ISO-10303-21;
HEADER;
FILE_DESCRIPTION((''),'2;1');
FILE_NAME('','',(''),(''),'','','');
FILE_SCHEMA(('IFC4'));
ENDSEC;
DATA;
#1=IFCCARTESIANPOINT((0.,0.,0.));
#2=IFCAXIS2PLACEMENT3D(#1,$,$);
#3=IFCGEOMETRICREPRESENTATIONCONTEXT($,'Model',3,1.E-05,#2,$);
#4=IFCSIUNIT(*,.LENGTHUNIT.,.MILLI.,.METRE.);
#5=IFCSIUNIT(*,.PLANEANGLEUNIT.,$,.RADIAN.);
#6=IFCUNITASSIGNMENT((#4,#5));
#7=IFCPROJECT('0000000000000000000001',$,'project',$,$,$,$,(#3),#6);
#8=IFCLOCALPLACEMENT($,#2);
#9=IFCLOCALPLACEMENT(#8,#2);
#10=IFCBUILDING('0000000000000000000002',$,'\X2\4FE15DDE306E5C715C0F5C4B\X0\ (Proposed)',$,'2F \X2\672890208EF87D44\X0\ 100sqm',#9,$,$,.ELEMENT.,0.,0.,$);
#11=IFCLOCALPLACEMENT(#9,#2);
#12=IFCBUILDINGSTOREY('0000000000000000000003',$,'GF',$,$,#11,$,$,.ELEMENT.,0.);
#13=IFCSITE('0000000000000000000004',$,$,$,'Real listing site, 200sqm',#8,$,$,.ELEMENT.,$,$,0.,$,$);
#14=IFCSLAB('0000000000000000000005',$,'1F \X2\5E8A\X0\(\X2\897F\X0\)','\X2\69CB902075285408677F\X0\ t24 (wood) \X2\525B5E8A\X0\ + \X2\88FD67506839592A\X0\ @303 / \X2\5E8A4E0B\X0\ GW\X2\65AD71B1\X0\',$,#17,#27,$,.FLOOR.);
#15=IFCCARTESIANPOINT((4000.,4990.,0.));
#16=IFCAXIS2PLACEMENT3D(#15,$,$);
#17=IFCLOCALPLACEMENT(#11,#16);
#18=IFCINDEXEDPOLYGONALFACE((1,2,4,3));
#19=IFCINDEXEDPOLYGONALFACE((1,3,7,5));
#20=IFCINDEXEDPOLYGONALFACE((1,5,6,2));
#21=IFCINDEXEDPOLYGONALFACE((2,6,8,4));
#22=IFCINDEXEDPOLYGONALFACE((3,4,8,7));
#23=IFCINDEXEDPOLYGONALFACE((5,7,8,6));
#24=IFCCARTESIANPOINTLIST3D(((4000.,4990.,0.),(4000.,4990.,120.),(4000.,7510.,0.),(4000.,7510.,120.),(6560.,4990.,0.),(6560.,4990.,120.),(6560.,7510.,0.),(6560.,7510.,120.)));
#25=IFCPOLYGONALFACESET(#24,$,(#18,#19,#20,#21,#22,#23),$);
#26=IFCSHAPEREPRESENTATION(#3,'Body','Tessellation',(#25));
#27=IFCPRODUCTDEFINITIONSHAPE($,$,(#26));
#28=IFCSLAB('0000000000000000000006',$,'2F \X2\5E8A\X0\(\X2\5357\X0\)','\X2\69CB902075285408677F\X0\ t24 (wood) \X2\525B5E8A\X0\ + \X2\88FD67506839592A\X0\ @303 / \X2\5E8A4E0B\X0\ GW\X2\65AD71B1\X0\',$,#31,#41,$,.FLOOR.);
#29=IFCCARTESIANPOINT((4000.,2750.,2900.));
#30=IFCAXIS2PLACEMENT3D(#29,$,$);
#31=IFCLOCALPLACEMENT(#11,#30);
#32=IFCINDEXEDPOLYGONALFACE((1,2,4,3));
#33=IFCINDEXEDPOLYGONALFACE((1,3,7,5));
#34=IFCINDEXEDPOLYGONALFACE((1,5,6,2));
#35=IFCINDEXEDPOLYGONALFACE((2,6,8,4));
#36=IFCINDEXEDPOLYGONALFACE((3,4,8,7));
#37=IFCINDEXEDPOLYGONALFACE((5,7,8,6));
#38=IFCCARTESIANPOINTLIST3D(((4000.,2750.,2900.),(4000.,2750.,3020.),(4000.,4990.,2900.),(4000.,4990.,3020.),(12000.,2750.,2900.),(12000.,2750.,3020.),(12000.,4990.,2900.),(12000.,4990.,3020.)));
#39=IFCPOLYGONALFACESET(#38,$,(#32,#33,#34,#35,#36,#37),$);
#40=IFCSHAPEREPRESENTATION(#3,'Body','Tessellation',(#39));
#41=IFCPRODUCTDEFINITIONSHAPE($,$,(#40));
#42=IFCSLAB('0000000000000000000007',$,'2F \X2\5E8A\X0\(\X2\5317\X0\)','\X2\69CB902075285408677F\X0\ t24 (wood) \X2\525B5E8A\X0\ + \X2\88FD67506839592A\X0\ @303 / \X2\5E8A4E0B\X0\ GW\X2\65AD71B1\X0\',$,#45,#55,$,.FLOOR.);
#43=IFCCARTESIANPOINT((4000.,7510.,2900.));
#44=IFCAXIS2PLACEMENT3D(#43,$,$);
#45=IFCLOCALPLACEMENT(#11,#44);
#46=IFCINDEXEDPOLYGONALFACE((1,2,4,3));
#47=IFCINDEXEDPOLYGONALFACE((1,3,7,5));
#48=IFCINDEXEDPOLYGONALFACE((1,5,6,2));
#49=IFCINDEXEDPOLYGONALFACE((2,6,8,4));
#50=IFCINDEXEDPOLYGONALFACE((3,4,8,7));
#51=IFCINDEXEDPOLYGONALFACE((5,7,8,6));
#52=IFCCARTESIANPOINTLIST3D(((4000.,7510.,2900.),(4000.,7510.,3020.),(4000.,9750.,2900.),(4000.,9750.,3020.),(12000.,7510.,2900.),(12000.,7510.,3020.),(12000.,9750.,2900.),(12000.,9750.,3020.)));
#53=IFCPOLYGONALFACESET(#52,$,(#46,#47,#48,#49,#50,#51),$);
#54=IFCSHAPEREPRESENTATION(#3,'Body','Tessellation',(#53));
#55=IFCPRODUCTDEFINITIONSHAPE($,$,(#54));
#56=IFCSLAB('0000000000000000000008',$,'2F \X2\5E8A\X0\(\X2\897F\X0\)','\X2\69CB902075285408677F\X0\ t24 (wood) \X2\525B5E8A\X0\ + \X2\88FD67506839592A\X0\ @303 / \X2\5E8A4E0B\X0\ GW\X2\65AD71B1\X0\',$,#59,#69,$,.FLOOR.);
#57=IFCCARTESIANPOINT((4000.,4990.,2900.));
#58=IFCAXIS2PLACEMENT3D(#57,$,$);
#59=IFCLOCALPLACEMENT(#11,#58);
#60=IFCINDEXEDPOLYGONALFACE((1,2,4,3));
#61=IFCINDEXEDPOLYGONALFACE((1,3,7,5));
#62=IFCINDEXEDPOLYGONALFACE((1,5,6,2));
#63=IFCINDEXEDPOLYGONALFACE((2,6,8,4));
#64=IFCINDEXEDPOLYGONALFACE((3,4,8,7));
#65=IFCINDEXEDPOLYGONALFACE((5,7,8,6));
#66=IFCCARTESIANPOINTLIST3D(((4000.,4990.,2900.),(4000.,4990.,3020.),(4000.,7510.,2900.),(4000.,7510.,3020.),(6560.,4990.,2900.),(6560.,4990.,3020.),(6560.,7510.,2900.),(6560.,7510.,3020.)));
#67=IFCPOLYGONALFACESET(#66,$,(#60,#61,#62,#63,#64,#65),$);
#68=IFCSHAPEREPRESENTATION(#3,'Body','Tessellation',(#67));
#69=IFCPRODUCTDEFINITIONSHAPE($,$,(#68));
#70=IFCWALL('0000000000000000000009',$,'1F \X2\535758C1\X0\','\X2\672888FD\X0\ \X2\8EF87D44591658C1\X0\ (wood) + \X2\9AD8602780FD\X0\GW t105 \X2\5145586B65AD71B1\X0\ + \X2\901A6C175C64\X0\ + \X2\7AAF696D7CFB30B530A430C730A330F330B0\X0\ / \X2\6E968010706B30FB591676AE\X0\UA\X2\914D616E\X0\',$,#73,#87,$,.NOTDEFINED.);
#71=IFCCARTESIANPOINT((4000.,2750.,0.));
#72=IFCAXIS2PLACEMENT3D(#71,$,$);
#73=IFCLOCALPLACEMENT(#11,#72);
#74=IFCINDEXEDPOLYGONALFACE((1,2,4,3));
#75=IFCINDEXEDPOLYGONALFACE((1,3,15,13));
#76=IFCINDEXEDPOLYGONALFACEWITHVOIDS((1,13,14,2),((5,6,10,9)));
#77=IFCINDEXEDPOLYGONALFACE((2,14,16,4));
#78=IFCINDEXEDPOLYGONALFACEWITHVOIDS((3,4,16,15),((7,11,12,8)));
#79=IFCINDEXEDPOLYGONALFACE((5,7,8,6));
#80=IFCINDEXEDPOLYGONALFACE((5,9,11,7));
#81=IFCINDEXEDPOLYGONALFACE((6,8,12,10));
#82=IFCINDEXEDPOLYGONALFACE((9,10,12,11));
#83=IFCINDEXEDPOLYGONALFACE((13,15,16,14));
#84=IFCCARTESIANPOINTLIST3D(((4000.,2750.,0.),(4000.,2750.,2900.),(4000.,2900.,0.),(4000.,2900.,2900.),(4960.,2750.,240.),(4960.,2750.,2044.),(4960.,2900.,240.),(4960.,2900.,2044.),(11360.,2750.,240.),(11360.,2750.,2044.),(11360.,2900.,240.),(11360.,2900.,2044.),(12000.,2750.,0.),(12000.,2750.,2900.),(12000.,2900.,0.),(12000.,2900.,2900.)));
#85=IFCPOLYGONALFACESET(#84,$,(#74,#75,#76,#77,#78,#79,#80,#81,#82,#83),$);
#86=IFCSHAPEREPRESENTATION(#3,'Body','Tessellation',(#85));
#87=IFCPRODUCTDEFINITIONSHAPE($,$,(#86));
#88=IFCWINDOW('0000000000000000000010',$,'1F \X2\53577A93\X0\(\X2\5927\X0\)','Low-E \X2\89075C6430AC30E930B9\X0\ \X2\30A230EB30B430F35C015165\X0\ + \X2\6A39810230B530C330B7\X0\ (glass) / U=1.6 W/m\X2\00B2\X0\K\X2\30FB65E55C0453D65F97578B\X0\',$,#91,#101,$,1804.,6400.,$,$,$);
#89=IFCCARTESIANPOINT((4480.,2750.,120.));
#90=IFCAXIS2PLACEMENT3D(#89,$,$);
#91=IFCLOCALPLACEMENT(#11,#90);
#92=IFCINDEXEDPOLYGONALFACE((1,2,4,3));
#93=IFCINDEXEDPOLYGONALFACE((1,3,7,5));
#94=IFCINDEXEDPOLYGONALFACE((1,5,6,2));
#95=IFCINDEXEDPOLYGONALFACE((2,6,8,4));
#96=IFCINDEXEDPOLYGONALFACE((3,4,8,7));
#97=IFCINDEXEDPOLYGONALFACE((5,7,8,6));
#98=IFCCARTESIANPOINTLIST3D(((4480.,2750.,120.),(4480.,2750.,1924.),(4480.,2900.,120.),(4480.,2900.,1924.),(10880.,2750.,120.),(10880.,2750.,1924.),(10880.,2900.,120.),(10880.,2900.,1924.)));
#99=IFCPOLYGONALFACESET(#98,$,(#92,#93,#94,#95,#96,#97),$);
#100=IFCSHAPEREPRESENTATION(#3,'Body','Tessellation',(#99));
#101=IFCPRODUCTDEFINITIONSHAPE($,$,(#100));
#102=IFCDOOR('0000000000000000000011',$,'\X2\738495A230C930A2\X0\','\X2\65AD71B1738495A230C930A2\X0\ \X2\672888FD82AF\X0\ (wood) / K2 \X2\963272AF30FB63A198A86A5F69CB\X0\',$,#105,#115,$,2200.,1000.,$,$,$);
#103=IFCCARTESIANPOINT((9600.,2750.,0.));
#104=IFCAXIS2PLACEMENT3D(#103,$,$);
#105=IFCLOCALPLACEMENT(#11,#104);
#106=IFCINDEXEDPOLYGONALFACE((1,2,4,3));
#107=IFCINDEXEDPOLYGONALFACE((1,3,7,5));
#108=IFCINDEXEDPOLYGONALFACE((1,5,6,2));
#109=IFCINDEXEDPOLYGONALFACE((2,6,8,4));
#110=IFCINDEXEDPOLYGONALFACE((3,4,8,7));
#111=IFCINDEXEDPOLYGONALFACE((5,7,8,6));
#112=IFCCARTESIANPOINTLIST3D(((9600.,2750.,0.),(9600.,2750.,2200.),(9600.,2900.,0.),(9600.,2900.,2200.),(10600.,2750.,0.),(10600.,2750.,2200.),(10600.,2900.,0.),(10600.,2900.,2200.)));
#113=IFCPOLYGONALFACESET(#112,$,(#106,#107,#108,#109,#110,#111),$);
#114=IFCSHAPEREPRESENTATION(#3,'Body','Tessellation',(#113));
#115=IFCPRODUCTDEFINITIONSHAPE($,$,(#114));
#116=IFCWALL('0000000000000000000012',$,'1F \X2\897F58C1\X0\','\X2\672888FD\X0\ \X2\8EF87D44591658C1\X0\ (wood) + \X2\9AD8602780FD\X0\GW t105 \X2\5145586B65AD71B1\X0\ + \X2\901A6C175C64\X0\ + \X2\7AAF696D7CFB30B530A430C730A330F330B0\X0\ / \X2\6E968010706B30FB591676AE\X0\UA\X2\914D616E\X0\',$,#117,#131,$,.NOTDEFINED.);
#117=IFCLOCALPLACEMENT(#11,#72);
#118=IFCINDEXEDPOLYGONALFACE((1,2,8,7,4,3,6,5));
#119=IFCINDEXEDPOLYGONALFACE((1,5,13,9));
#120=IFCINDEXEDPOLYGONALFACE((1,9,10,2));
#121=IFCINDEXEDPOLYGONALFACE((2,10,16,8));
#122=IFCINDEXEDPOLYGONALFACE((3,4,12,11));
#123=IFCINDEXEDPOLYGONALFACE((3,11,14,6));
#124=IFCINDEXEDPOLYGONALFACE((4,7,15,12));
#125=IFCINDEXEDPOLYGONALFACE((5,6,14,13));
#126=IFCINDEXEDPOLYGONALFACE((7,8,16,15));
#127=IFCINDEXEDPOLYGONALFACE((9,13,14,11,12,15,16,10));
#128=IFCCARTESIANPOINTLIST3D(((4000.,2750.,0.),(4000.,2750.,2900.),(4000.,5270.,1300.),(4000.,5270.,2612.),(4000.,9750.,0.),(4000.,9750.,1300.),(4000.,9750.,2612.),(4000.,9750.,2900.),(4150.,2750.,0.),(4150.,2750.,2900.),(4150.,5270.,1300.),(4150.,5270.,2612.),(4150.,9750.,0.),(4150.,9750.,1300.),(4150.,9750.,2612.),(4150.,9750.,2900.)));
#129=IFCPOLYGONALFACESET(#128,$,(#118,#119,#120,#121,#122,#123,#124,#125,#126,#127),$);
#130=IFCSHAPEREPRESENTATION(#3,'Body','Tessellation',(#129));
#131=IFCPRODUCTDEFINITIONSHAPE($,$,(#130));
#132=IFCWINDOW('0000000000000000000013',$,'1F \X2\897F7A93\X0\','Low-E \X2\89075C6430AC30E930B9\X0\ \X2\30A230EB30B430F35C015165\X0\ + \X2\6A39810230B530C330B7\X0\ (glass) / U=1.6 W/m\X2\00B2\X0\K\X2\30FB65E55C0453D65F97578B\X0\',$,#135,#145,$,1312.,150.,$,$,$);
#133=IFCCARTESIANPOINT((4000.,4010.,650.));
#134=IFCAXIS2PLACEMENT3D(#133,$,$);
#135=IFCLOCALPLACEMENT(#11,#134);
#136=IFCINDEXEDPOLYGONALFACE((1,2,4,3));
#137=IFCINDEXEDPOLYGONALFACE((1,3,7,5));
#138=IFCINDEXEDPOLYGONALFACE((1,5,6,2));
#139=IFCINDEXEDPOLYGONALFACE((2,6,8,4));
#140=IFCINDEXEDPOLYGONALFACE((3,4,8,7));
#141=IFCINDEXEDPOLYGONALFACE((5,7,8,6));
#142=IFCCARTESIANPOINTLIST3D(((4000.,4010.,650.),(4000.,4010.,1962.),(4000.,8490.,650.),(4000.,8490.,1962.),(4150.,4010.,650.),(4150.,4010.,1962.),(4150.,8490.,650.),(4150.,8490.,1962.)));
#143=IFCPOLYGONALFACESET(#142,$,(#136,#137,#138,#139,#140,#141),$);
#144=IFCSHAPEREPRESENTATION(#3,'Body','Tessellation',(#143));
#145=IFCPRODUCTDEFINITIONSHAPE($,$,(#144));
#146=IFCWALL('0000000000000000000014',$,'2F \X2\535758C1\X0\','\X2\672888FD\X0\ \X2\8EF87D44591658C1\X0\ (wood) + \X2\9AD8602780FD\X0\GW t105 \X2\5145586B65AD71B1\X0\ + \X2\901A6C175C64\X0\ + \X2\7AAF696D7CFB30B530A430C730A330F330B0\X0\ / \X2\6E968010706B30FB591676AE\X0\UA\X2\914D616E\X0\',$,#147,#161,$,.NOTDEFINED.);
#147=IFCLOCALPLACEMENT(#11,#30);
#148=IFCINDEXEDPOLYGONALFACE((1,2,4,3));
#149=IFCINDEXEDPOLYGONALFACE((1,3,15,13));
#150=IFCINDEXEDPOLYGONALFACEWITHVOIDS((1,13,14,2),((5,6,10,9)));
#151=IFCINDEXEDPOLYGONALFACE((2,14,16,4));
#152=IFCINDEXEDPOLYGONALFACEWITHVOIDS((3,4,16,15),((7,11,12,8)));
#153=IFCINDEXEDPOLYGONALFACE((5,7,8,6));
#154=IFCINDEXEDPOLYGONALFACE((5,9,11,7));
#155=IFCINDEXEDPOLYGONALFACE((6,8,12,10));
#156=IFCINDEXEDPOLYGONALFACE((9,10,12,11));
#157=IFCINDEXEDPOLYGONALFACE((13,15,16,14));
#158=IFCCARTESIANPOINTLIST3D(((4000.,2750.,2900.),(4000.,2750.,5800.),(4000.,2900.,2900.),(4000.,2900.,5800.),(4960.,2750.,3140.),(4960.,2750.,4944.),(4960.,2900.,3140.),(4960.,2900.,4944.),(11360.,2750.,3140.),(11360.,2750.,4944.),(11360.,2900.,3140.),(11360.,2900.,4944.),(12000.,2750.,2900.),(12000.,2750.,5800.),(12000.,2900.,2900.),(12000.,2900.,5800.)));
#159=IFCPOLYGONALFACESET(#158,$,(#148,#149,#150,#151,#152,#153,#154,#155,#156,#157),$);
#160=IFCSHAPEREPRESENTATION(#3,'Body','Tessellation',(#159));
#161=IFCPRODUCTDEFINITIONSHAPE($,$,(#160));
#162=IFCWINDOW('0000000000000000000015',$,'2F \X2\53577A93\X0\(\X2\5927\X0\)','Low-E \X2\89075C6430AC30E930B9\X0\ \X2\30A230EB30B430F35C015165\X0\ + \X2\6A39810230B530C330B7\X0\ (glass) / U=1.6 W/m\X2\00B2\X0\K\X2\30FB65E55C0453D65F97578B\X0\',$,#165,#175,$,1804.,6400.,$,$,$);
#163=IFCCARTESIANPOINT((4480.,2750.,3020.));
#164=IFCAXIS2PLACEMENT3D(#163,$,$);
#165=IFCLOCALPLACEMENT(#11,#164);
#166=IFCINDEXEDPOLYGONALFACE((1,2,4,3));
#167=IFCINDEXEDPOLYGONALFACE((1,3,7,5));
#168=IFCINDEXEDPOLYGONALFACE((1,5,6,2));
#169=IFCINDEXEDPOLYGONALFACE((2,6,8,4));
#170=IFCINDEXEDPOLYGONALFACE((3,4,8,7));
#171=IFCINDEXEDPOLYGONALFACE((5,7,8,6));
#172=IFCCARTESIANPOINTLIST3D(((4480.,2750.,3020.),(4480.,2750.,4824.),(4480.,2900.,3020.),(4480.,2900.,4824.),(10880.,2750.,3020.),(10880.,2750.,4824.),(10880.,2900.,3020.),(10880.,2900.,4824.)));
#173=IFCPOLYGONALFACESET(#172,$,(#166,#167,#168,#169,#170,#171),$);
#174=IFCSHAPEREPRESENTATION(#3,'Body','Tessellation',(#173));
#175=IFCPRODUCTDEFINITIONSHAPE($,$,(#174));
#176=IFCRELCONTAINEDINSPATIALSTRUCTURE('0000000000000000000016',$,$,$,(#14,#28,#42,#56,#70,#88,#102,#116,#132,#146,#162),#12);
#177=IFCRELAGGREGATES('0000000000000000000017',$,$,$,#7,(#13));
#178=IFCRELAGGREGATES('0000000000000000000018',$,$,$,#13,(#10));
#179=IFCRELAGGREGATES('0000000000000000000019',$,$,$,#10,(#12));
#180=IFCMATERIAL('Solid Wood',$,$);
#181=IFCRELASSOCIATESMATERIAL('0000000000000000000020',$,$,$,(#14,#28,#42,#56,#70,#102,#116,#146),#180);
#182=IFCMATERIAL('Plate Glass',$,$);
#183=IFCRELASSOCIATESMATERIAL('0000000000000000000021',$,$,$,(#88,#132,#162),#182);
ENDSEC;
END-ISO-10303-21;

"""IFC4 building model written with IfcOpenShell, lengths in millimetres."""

from ifc_helpers import new_model, si_unit, frame, frame_2d, origin, place, context, project, spatial, rectangle, extrude, material, element, fill, save


model = new_model("IFC4")

# Units and contexts
model_context = context("Model", 3, precision=1e-05, world=origin())
ifc_project = project(units=[si_unit("LENGTHUNIT", "METRE", prefix="MILLI"), si_unit("PLANEANGLEUNIT", "RADIAN")], contexts=[model_context])

# Site, building, storey
site_placement = place(None, origin())
site = spatial("IfcSite", under=ifc_project, at=site_placement, ObjectType="Real listing site, 200sqm", CompositionType="ELEMENT", RefElevation=0.0)
building_placement = place(site_placement, origin())
building = spatial("IfcBuilding", under=site, at=building_placement, Name="信州の山小屋 (Proposed)", ObjectType="2F 木造軸組 100sqm", CompositionType="ELEMENT", ElevationOfRefHeight=0.0, ElevationOfTerrain=0.0)
storey_placement = place(building_placement, origin())
storey = spatial("IfcBuildingStorey", under=building, at=storey_placement, Name="GF", CompositionType="ELEMENT", Elevation=0.0)

# Slabs
ifc_material_1 = material(Name="Solid Wood")
slab_1_placement = place(storey_placement, frame((4000.0, 4990.0, 0.0)))
element("IfcSlab", 1, at=slab_1_placement, inside=storey, material=ifc_material_1, Name="1F 床(西)", Description="構造用合板 t24 (wood) 剛床 + 製材根太 @303 / 床下 GW断熱", PredefinedType="FLOOR", context=model_context, shape_type="SweptSolid", body=[
    extrude(rectangle(XDim=2560.0, YDim=2520.0, at=frame_2d((1280.0, 1260.0))), frame((4000.0, 4990.0, 0.0)), (0.0, 0.0, 1.0), 120.0),
])
slab_2_placement = place(storey_placement, frame((4000.0, 2750.0, 2900.0)))
element("IfcSlab", 2, at=slab_2_placement, inside=storey, material=ifc_material_1, Name="2F 床(南)", Description="構造用合板 t24 (wood) 剛床 + 製材根太 @303 / 床下 GW断熱", PredefinedType="FLOOR", context=model_context, shape_type="SweptSolid", body=[
    extrude(rectangle(XDim=8000.0, YDim=2240.0, at=frame_2d((4000.0, 1120.0))), frame((4000.0, 2750.0, 2900.0)), (0.0, 0.0, 1.0), 120.0),
])
slab_3_placement = place(storey_placement, frame((4000.0, 7510.0, 2900.0)))
element("IfcSlab", 3, at=slab_3_placement, inside=storey, material=ifc_material_1, Name="2F 床(北)", Description="構造用合板 t24 (wood) 剛床 + 製材根太 @303 / 床下 GW断熱", PredefinedType="FLOOR", context=model_context, shape_type="SweptSolid", body=[
    extrude(rectangle(XDim=8000.0, YDim=2240.0, at=frame_2d((4000.0, 1120.0))), frame((4000.0, 7510.0, 2900.0)), (0.0, 0.0, 1.0), 120.0),
])
slab_4_placement = place(storey_placement, frame((4000.0, 4990.0, 2900.0)))
element("IfcSlab", 4, at=slab_4_placement, inside=storey, material=ifc_material_1, Name="2F 床(西)", Description="構造用合板 t24 (wood) 剛床 + 製材根太 @303 / 床下 GW断熱", PredefinedType="FLOOR", context=model_context, shape_type="SweptSolid", body=[
    extrude(rectangle(XDim=2560.0, YDim=2520.0, at=frame_2d((1280.0, 1260.0))), frame((4000.0, 4990.0, 2900.0)), (0.0, 0.0, 1.0), 120.0),
])

# Wall, openings, window, door
wall_1_placement = place(storey_placement, frame((4000.0, 2750.0, 0.0)))
wall_1 = element("IfcWall", 5, at=wall_1_placement, inside=storey, material=ifc_material_1, Name="1F 南壁", Description="木製 軸組外壁 (wood) + 高性能GW t105 充填断熱 + 通気層 + 窯業系サイディング / 準耐火・外皮UA配慮", PredefinedType="NOTDEFINED", context=model_context, shape_type="SweptSolid", body=[
    extrude(rectangle(XDim=8000.0, YDim=150.0, at=frame_2d((4000.0, 75.0))), frame((4000.0, 2750.0, 0.0)), (0.0, 0.0, 1.0), 2900.0),
])
opening_1_placement = place(storey_placement, frame((4480.0, 2750.0, 120.0)))
opening_1 = element("IfcOpeningElement", 6, at=opening_1_placement, cuts=wall_1, PredefinedType="NOTDEFINED", context=model_context, shape_type="SweptSolid", body=[
    extrude(rectangle(XDim=6400.0, YDim=150.0, at=frame_2d((3200.0, 75.0))), frame((4480.0, 2750.0, 120.0)), (0.0, 0.0, 1.0), 1804.0),
])
opening_2_placement = place(storey_placement, frame((9600.0, 2750.0, 0.0)))
opening_2 = element("IfcOpeningElement", 7, at=opening_2_placement, cuts=wall_1, PredefinedType="NOTDEFINED", context=model_context, shape_type="SweptSolid", body=[
    extrude(rectangle(XDim=1000.0, YDim=150.0, at=frame_2d((500.0, 75.0))), frame((9600.0, 2750.0, 0.0)), (0.0, 0.0, 1.0), 2200.0),
])
ifc_material_2 = material(Name="Plate Glass")
window_1_placement = place(storey_placement, frame((4480.0, 2750.0, 120.0)))
window_1 = element("IfcWindow", 8, at=window_1_placement, inside=storey, material=ifc_material_2, Name="1F 南窓(大)", Description="Low-E 複層ガラス アルゴン封入 + 樹脂サッシ (glass) / U=1.6 W/m²K・日射取得型", OverallHeight=1804.0, OverallWidth=6400.0, context=model_context, shape_type="SweptSolid", body=[
    extrude(rectangle(XDim=6400.0, YDim=150.0, at=frame_2d((3200.0, 75.0))), frame((4480.0, 2750.0, 120.0)), (0.0, 0.0, 1.0), 1804.0),
])
fill(opening_1, window_1)
door_placement = place(storey_placement, frame((9600.0, 2750.0, 0.0)))
door = element("IfcDoor", 9, at=door_placement, inside=storey, material=ifc_material_1, Name="玄関ドア", Description="断熱玄関ドア 木製芯 (wood) / K2 防犯・採風機構", OverallHeight=2200.0, OverallWidth=1000.0, context=model_context, shape_type="SweptSolid", body=[
    extrude(rectangle(XDim=1000.0, YDim=150.0, at=frame_2d((500.0, 75.0))), frame((9600.0, 2750.0, 0.0)), (0.0, 0.0, 1.0), 2200.0),
])
fill(opening_2, door)

# Walls, openings, windows
wall_2_placement = place(storey_placement, frame((4000.0, 2750.0, 0.0)))
wall_2 = element("IfcWall", 10, at=wall_2_placement, inside=storey, material=ifc_material_1, Name="1F 西壁", Description="木製 軸組外壁 (wood) + 高性能GW t105 充填断熱 + 通気層 + 窯業系サイディング / 準耐火・外皮UA配慮", PredefinedType="NOTDEFINED", context=model_context, shape_type="SweptSolid", body=[
    extrude(rectangle(XDim=150.0, YDim=7000.0, at=frame_2d((75.0, 3500.0))), frame((4000.0, 2750.0, 0.0)), (0.0, 0.0, 1.0), 2900.0),
])
opening_3_placement = place(storey_placement, frame((4000.0, 4010.0, 650.0)))
opening_3 = element("IfcOpeningElement", 11, at=opening_3_placement, cuts=wall_2, PredefinedType="NOTDEFINED", context=model_context, shape_type="SweptSolid", body=[
    extrude(rectangle(XDim=150.0, YDim=4480.0, at=frame_2d((75.0, 2240.0))), frame((4000.0, 4010.0, 650.0)), (0.0, 0.0, 1.0), 1312.0),
])
window_2_placement = place(storey_placement, frame((4000.0, 4010.0, 650.0)))
window_2 = element("IfcWindow", 12, at=window_2_placement, inside=storey, material=ifc_material_2, Name="1F 西窓", Description="Low-E 複層ガラス アルゴン封入 + 樹脂サッシ (glass) / U=1.6 W/m²K・日射取得型", OverallHeight=1312.0, OverallWidth=150.0, context=model_context, shape_type="SweptSolid", body=[
    extrude(rectangle(XDim=150.0, YDim=4480.0, at=frame_2d((75.0, 2240.0))), frame((4000.0, 4010.0, 650.0)), (0.0, 0.0, 1.0), 1312.0),
])
fill(opening_3, window_2)
wall_3_placement = place(storey_placement, frame((4000.0, 2750.0, 2900.0)))
wall_3 = element("IfcWall", 13, at=wall_3_placement, inside=storey, material=ifc_material_1, Name="2F 南壁", Description="木製 軸組外壁 (wood) + 高性能GW t105 充填断熱 + 通気層 + 窯業系サイディング / 準耐火・外皮UA配慮", PredefinedType="NOTDEFINED", context=model_context, shape_type="SweptSolid", body=[
    extrude(rectangle(XDim=8000.0, YDim=150.0, at=frame_2d((4000.0, 75.0))), frame((4000.0, 2750.0, 2900.0)), (0.0, 0.0, 1.0), 2900.0),
])
opening_4_placement = place(storey_placement, frame((4480.0, 2750.0, 3020.0)))
opening_4 = element("IfcOpeningElement", 14, at=opening_4_placement, cuts=wall_3, PredefinedType="NOTDEFINED", context=model_context, shape_type="SweptSolid", body=[
    extrude(rectangle(XDim=6400.0, YDim=150.0, at=frame_2d((3200.0, 75.0))), frame((4480.0, 2750.0, 3020.0)), (0.0, 0.0, 1.0), 1804.0),
])
window_3_placement = place(storey_placement, frame((4480.0, 2750.0, 3020.0)))
window_3 = element("IfcWindow", 15, at=window_3_placement, inside=storey, material=ifc_material_2, Name="2F 南窓(大)", Description="Low-E 複層ガラス アルゴン封入 + 樹脂サッシ (glass) / U=1.6 W/m²K・日射取得型", OverallHeight=1804.0, OverallWidth=6400.0, context=model_context, shape_type="SweptSolid", body=[
    extrude(rectangle(XDim=6400.0, YDim=150.0, at=frame_2d((3200.0, 75.0))), frame((4480.0, 2750.0, 3020.0)), (0.0, 0.0, 1.0), 1804.0),
])
fill(opening_4, window_3)

save(model, "model.ifc")
